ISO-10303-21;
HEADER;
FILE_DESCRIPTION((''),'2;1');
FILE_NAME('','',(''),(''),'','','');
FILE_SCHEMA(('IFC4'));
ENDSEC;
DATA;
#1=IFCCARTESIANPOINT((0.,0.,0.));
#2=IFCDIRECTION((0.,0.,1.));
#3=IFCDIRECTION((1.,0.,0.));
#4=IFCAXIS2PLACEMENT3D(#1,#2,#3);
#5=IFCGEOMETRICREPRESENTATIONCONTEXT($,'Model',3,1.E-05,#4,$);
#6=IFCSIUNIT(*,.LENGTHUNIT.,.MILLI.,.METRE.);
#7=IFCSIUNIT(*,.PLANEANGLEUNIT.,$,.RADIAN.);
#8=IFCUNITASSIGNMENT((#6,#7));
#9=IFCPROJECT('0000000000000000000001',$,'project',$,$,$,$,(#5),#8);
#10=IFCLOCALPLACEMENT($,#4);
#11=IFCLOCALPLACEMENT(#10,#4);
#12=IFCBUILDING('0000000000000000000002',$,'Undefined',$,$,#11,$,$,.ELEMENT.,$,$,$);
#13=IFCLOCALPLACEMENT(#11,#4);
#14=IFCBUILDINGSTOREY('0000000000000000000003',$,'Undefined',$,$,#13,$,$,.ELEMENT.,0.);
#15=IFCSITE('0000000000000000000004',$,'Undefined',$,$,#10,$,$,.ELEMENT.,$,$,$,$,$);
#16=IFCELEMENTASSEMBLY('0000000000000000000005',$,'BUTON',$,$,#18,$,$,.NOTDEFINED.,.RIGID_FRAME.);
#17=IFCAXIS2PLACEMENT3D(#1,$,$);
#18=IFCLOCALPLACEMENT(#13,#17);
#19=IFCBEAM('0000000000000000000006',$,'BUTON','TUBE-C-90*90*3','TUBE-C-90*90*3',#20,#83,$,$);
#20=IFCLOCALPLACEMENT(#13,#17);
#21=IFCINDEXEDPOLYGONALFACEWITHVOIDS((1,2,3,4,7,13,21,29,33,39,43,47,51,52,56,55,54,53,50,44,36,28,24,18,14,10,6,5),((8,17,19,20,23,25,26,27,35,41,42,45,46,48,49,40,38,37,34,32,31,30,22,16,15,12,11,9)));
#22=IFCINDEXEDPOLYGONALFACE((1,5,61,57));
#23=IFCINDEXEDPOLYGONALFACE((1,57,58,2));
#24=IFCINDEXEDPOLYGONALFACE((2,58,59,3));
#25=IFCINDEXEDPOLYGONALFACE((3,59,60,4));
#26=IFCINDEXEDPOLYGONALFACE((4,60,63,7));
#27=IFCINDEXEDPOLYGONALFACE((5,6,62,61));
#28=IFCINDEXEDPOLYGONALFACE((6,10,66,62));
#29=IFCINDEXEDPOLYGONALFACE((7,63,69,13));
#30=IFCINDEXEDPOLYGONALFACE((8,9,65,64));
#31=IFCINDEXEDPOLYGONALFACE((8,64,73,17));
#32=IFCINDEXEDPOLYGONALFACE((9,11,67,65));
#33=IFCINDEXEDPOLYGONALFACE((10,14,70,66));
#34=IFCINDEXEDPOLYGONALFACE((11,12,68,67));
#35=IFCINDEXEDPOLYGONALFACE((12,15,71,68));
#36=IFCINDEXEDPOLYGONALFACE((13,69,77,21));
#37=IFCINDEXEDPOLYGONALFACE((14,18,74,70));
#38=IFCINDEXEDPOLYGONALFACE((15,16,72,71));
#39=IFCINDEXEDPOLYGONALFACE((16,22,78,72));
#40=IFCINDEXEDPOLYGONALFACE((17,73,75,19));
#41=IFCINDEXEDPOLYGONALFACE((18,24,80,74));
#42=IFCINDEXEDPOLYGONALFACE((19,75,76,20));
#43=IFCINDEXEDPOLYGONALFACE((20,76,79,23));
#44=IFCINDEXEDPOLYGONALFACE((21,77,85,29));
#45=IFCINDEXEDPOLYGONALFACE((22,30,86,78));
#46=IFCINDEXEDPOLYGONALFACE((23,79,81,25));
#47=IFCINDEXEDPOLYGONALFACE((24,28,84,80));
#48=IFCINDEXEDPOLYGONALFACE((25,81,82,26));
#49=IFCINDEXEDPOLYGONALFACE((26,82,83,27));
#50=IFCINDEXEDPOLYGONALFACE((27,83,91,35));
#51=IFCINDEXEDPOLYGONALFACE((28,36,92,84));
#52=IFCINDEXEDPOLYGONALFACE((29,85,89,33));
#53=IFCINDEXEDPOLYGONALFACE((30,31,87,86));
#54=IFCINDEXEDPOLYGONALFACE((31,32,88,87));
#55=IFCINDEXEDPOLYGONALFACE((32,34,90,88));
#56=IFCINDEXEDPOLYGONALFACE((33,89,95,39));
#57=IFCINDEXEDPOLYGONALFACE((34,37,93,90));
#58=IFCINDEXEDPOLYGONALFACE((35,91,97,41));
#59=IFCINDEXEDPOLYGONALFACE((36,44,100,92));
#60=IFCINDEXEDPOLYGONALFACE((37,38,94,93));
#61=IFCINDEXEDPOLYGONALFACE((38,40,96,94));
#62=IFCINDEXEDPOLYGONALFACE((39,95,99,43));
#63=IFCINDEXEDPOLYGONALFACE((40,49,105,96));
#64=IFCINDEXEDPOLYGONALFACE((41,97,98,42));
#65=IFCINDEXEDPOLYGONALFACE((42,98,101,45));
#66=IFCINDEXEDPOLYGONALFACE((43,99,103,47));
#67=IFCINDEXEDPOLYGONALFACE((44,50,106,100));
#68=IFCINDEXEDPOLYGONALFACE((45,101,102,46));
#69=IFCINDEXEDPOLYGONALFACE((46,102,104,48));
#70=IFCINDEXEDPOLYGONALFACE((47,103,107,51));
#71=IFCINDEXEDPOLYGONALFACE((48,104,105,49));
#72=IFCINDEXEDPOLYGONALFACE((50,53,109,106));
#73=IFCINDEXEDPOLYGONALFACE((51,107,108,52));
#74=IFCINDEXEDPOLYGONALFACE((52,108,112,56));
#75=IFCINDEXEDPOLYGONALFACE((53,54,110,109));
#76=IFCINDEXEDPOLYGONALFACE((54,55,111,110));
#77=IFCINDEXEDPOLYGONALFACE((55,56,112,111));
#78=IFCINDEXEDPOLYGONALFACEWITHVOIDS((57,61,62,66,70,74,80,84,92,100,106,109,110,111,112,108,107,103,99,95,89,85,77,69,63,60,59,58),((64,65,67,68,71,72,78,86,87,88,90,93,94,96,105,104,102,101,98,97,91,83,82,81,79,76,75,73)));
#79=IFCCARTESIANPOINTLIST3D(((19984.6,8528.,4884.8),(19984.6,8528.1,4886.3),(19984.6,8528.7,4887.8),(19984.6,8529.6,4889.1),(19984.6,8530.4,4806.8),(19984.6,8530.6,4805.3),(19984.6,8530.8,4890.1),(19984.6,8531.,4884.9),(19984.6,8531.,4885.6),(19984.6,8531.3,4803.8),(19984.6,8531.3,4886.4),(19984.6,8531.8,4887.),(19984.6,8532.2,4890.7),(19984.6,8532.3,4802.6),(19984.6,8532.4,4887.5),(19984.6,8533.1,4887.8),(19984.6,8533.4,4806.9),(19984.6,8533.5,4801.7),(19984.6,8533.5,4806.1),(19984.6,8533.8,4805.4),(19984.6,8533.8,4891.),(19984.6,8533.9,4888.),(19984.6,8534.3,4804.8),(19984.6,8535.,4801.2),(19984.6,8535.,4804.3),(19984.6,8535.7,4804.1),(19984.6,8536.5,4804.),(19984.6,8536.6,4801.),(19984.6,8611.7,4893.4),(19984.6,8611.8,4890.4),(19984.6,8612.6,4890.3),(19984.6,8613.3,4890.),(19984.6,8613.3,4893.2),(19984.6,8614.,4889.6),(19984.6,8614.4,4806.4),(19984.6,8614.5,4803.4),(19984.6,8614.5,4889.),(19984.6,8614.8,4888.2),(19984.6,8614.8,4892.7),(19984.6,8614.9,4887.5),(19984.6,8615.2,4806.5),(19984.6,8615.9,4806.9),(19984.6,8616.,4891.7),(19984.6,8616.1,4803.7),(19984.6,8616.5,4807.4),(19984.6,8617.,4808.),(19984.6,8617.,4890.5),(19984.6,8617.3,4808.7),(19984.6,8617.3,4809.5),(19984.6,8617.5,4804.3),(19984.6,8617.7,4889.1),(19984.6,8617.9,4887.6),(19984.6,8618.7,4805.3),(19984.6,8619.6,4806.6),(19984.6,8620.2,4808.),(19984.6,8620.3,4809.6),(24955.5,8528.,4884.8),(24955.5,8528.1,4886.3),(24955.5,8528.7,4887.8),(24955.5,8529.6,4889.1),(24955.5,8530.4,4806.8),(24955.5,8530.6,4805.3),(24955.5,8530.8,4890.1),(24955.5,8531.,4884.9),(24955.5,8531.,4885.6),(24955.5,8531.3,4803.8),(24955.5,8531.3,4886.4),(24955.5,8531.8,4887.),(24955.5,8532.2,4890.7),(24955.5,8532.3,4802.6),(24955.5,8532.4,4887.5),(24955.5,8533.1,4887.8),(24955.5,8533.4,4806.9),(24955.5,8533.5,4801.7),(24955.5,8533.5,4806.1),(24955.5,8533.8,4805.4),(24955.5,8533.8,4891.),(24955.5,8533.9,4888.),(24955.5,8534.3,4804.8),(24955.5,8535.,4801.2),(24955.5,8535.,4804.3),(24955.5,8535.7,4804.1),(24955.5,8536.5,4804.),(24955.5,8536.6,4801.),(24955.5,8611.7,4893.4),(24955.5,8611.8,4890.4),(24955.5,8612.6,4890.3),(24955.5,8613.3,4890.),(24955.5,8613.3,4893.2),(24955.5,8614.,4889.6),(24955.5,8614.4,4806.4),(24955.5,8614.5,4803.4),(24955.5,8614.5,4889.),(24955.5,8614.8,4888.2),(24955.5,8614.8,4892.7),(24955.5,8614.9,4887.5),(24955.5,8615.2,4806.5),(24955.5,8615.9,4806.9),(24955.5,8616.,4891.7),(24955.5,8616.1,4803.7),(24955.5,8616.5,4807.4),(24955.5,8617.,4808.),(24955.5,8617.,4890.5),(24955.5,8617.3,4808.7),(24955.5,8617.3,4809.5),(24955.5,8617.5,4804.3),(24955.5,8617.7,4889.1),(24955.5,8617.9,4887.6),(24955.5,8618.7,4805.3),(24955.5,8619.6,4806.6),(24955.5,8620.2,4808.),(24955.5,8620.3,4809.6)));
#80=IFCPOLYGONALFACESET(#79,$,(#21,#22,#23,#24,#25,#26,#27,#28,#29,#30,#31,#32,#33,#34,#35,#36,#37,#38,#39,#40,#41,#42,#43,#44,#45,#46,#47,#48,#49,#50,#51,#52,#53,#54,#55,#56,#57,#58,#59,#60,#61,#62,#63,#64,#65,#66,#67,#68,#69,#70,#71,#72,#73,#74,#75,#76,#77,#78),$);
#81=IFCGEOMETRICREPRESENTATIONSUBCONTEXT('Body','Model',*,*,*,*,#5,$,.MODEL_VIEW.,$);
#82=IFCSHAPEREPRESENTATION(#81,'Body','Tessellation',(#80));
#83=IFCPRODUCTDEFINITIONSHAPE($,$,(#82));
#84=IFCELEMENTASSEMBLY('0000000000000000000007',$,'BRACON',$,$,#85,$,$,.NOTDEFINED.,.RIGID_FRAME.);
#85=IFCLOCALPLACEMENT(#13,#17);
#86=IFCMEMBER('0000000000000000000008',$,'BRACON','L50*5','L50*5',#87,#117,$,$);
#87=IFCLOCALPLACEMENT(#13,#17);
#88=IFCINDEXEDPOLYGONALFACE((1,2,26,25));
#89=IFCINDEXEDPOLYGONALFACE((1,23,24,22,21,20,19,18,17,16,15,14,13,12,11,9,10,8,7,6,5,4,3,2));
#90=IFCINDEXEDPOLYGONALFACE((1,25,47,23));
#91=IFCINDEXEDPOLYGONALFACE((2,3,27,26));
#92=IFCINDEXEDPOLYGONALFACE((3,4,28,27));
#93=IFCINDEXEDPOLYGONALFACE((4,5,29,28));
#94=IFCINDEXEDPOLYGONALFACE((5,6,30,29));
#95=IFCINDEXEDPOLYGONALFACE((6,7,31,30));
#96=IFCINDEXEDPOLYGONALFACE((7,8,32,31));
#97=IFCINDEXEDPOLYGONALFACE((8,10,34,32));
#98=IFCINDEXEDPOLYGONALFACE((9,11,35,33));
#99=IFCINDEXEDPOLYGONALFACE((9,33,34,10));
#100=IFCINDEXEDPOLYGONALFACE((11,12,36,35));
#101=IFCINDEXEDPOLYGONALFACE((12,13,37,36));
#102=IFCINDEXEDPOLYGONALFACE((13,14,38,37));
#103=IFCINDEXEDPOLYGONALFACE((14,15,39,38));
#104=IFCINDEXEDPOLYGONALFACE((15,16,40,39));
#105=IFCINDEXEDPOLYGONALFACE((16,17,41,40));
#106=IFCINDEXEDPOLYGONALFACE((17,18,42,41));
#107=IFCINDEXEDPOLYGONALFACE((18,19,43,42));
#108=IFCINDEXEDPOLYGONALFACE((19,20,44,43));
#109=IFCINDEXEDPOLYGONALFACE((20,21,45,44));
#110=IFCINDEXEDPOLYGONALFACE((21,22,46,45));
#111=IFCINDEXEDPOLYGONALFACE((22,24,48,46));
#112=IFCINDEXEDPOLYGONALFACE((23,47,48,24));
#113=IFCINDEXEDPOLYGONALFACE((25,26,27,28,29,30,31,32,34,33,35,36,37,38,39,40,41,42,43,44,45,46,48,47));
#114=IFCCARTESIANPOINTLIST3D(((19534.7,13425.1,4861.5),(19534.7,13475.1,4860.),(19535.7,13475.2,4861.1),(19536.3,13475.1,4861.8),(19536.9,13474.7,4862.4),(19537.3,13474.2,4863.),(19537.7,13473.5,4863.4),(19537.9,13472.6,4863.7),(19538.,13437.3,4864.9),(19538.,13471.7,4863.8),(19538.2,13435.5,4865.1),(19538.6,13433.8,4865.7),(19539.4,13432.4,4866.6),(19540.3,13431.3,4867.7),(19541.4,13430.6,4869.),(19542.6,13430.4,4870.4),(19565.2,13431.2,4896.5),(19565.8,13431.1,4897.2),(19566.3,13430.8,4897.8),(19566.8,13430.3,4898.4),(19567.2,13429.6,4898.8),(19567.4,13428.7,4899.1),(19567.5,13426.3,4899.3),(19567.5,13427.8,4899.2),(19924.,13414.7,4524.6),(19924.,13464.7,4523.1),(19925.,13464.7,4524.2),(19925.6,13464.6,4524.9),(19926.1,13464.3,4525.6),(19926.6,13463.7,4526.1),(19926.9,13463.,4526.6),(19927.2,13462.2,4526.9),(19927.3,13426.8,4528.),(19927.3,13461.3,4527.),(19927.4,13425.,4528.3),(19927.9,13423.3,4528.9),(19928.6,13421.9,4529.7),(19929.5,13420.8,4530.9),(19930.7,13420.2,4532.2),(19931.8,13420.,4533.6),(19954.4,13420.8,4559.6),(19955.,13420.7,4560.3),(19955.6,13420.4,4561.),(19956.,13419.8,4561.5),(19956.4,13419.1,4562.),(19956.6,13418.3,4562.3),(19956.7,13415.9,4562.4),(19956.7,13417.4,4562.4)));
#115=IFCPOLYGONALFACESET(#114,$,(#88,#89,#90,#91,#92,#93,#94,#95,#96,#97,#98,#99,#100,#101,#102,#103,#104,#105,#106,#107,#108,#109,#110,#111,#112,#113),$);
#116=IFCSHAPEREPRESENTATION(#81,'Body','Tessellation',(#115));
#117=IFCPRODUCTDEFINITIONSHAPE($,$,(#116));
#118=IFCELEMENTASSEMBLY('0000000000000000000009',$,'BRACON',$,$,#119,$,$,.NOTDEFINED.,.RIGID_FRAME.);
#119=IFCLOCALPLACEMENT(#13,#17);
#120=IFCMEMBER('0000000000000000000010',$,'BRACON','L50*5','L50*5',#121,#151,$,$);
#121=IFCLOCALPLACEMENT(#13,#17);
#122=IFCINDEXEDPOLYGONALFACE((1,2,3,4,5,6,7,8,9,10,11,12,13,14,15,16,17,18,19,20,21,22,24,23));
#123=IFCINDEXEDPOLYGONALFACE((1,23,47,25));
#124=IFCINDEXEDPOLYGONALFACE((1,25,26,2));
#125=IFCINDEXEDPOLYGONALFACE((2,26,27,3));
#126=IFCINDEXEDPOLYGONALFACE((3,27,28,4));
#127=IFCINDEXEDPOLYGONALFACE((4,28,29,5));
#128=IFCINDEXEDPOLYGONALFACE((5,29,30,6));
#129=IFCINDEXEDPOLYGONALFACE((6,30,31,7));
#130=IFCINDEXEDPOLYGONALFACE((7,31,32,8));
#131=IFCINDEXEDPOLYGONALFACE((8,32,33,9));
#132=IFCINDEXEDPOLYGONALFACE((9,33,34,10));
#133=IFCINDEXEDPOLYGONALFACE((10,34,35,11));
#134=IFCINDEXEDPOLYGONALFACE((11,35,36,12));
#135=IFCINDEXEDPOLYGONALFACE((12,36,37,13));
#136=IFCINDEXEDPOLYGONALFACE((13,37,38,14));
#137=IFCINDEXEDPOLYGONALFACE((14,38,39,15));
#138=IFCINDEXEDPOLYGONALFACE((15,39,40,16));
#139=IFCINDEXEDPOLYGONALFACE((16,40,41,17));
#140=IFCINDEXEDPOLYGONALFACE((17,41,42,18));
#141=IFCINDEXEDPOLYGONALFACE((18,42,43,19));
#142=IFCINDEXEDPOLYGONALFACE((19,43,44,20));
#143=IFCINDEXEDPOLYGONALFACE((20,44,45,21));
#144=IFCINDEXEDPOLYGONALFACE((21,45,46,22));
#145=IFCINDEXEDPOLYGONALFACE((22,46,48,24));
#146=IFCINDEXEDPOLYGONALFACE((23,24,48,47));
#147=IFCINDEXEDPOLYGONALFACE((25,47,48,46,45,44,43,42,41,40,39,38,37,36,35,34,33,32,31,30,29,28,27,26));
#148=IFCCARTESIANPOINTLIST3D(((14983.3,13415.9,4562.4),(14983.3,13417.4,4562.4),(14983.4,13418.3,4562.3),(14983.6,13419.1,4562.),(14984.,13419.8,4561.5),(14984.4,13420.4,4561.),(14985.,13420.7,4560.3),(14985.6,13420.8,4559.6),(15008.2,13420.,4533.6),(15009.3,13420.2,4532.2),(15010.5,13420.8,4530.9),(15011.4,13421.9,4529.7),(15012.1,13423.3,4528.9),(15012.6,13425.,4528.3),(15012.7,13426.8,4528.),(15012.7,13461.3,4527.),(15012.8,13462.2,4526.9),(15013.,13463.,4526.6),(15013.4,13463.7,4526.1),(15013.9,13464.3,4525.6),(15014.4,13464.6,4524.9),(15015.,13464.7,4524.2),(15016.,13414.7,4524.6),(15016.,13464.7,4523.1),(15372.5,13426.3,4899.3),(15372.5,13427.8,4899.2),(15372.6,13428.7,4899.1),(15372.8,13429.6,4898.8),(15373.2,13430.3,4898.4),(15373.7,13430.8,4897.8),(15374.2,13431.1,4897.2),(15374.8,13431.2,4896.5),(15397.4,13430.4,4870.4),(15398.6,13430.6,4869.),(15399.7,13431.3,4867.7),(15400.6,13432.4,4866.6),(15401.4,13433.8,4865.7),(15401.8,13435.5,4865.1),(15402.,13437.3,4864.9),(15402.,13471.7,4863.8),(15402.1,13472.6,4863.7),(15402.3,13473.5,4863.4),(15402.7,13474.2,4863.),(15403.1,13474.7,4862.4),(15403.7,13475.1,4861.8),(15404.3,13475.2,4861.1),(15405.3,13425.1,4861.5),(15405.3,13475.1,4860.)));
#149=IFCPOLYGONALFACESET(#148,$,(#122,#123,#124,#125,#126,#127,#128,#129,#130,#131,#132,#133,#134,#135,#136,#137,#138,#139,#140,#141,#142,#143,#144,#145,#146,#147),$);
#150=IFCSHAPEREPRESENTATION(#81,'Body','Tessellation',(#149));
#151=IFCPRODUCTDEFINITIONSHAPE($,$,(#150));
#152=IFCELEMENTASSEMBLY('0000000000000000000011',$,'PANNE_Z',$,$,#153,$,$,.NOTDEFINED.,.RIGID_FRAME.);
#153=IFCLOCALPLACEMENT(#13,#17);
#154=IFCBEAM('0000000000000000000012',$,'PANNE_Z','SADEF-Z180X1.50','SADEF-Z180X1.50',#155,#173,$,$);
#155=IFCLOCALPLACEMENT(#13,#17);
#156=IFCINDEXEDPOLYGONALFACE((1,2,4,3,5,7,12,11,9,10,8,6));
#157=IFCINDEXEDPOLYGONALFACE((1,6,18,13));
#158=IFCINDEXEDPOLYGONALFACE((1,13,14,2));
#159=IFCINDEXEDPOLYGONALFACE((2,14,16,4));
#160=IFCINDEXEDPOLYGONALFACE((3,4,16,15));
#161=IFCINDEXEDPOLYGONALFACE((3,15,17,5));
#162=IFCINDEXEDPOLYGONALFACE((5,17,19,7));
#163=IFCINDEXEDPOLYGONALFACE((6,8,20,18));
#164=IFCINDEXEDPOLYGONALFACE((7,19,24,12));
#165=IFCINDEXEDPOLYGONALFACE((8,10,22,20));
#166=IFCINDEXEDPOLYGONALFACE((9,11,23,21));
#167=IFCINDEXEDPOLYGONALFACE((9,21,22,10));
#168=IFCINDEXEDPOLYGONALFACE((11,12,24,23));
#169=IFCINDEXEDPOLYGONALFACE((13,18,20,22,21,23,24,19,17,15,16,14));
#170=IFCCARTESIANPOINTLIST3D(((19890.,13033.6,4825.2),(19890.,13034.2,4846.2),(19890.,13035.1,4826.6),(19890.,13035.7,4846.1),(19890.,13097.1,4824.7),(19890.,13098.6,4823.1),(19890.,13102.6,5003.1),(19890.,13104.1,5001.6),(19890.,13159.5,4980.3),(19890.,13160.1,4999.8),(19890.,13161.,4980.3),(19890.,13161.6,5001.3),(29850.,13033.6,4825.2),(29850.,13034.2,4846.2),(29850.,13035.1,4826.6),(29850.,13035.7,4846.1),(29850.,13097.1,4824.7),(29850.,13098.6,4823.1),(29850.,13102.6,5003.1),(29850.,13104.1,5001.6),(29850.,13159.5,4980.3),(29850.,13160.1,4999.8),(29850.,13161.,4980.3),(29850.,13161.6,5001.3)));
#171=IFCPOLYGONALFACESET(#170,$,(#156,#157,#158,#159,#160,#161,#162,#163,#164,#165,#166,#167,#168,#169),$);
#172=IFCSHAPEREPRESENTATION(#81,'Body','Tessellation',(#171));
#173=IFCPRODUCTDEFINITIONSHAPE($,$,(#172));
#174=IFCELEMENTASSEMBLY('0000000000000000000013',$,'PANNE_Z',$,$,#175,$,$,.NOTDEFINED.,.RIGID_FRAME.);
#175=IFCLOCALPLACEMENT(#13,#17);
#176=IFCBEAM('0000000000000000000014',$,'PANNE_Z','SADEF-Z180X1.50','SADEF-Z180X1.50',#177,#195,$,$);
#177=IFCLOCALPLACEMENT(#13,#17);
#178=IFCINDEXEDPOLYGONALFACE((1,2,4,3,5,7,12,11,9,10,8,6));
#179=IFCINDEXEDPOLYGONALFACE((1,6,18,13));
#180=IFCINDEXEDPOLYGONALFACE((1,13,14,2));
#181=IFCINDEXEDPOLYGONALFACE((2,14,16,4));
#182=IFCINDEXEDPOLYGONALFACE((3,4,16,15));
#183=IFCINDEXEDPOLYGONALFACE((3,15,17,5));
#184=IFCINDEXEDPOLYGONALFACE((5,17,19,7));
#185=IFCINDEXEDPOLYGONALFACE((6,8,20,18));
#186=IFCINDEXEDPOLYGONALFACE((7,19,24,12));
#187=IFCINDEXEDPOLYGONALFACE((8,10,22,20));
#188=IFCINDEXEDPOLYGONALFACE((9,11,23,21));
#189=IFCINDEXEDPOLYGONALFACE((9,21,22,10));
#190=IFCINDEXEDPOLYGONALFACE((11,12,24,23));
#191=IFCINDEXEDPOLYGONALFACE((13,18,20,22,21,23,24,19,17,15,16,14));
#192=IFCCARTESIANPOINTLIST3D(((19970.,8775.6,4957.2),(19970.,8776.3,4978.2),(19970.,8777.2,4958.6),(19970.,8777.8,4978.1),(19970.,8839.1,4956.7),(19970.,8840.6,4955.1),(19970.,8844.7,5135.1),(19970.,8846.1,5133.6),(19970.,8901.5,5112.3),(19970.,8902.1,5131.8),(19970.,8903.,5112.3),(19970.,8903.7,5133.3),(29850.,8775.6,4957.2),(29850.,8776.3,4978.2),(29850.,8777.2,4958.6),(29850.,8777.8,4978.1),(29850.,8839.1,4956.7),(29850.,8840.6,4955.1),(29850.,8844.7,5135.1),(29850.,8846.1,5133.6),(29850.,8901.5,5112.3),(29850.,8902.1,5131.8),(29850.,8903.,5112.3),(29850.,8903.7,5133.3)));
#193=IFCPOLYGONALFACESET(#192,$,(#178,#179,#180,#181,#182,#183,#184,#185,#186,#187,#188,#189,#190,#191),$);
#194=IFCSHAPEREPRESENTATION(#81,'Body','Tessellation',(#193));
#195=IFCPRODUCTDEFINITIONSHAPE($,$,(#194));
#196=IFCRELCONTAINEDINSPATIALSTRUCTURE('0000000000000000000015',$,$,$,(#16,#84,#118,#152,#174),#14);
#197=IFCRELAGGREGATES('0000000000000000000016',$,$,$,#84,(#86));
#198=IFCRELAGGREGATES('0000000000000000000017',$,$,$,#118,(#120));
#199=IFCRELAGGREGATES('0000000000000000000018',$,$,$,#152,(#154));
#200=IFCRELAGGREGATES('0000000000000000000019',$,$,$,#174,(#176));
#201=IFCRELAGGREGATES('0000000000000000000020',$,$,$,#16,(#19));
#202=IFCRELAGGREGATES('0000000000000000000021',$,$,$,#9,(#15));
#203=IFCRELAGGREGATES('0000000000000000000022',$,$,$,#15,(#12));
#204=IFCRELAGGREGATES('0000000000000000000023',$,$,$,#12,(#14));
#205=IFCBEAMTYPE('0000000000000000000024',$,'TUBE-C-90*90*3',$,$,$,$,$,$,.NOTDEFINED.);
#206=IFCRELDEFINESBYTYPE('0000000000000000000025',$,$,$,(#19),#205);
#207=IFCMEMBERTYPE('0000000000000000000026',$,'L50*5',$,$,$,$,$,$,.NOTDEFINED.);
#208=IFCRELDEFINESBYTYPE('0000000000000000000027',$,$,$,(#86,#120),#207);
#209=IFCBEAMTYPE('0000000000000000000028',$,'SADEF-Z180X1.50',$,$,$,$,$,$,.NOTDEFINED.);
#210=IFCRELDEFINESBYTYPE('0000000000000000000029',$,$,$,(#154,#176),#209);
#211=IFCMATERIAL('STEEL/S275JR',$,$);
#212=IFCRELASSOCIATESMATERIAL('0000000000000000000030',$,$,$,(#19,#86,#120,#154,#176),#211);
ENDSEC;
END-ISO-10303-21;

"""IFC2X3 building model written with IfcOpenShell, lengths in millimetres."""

from ifc_helpers import new_model, si_unit, frame, origin_with_axes, origin_2d_with_axis, place, context, subcontext, project, spatial, polyline, hollow_rectangle, l_section, outline, extrude, clip, halfspace, material, type_object, element, aggregate, save


model = new_model("IFC2X3")

# Units and contexts
model_context = context("Model", 3, precision=1e-05, world=origin_with_axes())
body_context = subcontext(model_context, "Body", "Model", "MODEL_VIEW")
ifc_project = project(units=[si_unit("LENGTHUNIT", "METRE", prefix="MILLI"), si_unit("PLANEANGLEUNIT", "RADIAN")], contexts=[model_context])

# Site, building, storey
site_placement = place(None, origin_with_axes())
site = spatial("IfcSite", under=ifc_project, at=site_placement, Name="Undefined", CompositionType="ELEMENT")
building_placement = place(site_placement, origin_with_axes())
building = spatial("IfcBuilding", under=site, at=building_placement, Name="Undefined", CompositionType="ELEMENT")
storey_placement = place(building_placement, origin_with_axes())
storey = spatial("IfcBuildingStorey", under=building, at=storey_placement, Name="Undefined", CompositionType="ELEMENT", Elevation=0.0)

# Element assembly, beam
ifc_material_1 = material(Name="STEEL/S275JR")
beam_type_1 = type_object("IfcBeamType", Name="TUBE-C-90*90*3", PredefinedType="NOTDEFINED")
assembly_1_placement = place(storey_placement, origin_with_axes())
assembly_1 = element("IfcElementAssembly", 1, at=assembly_1_placement, inside=storey, Name="BUTON", AssemblyPlace="NOTDEFINED", PredefinedType="RIGID_FRAME")
beam_1_placement = place(assembly_1_placement, frame((19970.0, 8574.2, 4847.2), z_axis=(0.0, 0.99952, 0.030986), x_axis=(1.0, 0.0, 0.0)))
beam_1 = element("IfcBeam", 2, at=beam_1_placement, type_object=beam_type_1, material=ifc_material_1, Name="BUTON", Description="TUBE-C-90*90*3", ObjectType="TUBE-C-90*90*3", context=body_context, shape_type="Clipping", body=[
    clip(clip(extrude(hollow_rectangle(XDim=90.0, YDim=90.0, WallThickness=3.0, InnerFilletRadius=3.0, OuterFilletRadius=6.0, at=origin_2d_with_axis()), frame((4985.5, 0.0, 0.0), z_axis=(-1.0, 0.0, 0.0), x_axis=(0.0, -1.0, 0.0)), (0.0, 0.0, 1.0), 4970.9), halfspace(frame((4985.5, 0.0, -45.0), z_axis=(-1.0, 0.0, 0.0), x_axis=(0.0, 1.0, 0.0)), True)), halfspace(frame((14.5, 0.0, -45.0), z_axis=(1.0, 0.0, 0.0), x_axis=(0.0, -1.0, 0.0)), True)),
])

# Element assemblies, members
assembly_2_placement = place(storey_placement, origin_with_axes())
assembly_2 = element("IfcElementAssembly", 3, at=assembly_2_placement, inside=storey, Name="BRACON", AssemblyPlace="NOTDEFINED", PredefinedType="RIGID_FRAME")
member_type = type_object("IfcMemberType", Name="L50*5", PredefinedType="NOTDEFINED")
member_1_placement = place(assembly_2_placement, frame((19940.3, 13440.3, 4542.8), z_axis=(0.654574, 0.023425, 0.755635), x_axis=(-0.755998, 0.020283, 0.65426)))
member_1 = element("IfcMember", 4, at=member_1_placement, type_object=member_type, material=ifc_material_1, Name="BRACON", Description="L50*5", ObjectType="L50*5", context=body_context, shape_type="SweptSolid", body=[
    extrude(l_section(Depth=50.0, Width=50.0, Thickness=5.0, FilletRadius=7.0, EdgeRadius=3.5, at=origin_2d_with_axis()), frame((514.9, 0.0, 0.0), z_axis=(-1.0, 0.0, 0.0), x_axis=(0.0, -1.0, 0.0)), (0.0, 0.0, 1.0), 514.9),
])
aggregate(assembly_2, [member_1])
assembly_3_placement = place(storey_placement, origin_with_axes())
assembly_3 = element("IfcElementAssembly", 5, at=assembly_3_placement, inside=storey, Name="BRACON", AssemblyPlace="NOTDEFINED", PredefinedType="RIGID_FRAME")
member_2_placement = place(assembly_3_placement, frame((15388.9, 13450.7, 4879.6), z_axis=(-0.654574, 0.023425, 0.755635), x_axis=(-0.755998, -0.020283, -0.65426)))
member_2 = element("IfcMember", 6, at=member_2_placement, type_object=member_type, material=ifc_material_1, Name="BRACON", Description="L50*5", ObjectType="L50*5", context=body_context, shape_type="SweptSolid", body=[
    extrude(l_section(Depth=50.0, Width=50.0, Thickness=5.0, FilletRadius=7.0, EdgeRadius=3.5, at=origin_2d_with_axis()), frame((514.9, 0.0, 0.0), z_axis=(-1.0, 0.0, 0.0), x_axis=(0.0, -1.0, 0.0)), (0.0, 0.0, 1.0), 514.9),
])
aggregate(assembly_3, [member_2])

# Element assemblies, beams
assembly_4_placement = place(storey_placement, origin_with_axes())
assembly_4 = element("IfcElementAssembly", 7, at=assembly_4_placement, inside=storey, Name="PANNE_Z", AssemblyPlace="NOTDEFINED", PredefinedType="RIGID_FRAME")
beam_type_2 = type_object("IfcBeamType", Name="SADEF-Z180X1.50", PredefinedType="NOTDEFINED")
beam_2_placement = place(assembly_4_placement, frame((19890.0, 13100.6, 4913.1), z_axis=(0.0, 0.031032, 0.999518), x_axis=(1.0, 0.0, 0.0)))
beam_2 = element("IfcBeam", 8, at=beam_2_placement, type_object=beam_type_2, material=ifc_material_1, Name="PANNE_Z", Description="SADEF-Z180X1.50", ObjectType="SADEF-Z180X1.50", context=body_context, shape_type="SweptSolid", body=[
    extrude(outline(polyline([(-56.7, 69.0), (-58.2, 69.0), (-58.2, 90.0), (0.8, 90.0), (0.7, -88.5), (62.7, -88.5), (62.7, -69.0), (64.2, -69.0), (64.2, -90.0), (-0.8, -90.0), (-0.7, 88.5), (-56.7, 88.5), (-56.7, 69.0)])), frame((9960.0, 0.0, 0.0), z_axis=(-1.0, 0.0, 0.0), x_axis=(0.0, -1.0, 0.0)), (0.0, 0.0, 1.0), 9960.0),
])
aggregate(assembly_4, [beam_2])
assembly_5_placement = place(storey_placement, origin_with_axes())
assembly_5 = element("IfcElementAssembly", 9, at=assembly_5_placement, inside=storey, Name="PANNE_Z", AssemblyPlace="NOTDEFINED", PredefinedType="RIGID_FRAME")
beam_3_placement = place(assembly_5_placement, frame((19970.0, 8842.6, 5045.1), z_axis=(0.0, 0.031032, 0.999518), x_axis=(1.0, 0.0, 0.0)))
beam_3 = element("IfcBeam", 10, at=beam_3_placement, type_object=beam_type_2, material=ifc_material_1, Name="PANNE_Z", Description="SADEF-Z180X1.50", ObjectType="SADEF-Z180X1.50", context=body_context, shape_type="SweptSolid", body=[
    extrude(outline(polyline([(-56.7, 69.0), (-58.2, 69.0), (-58.2, 90.0), (0.8, 90.0), (0.7, -88.5), (62.7, -88.5), (62.7, -69.0), (64.2, -69.0), (64.2, -90.0), (-0.8, -90.0), (-0.7, 88.5), (-56.7, 88.5), (-56.7, 69.0)])), frame((9880.0, 0.0, 0.0), z_axis=(-1.0, 0.0, 0.0), x_axis=(0.0, -1.0, 0.0)), (0.0, 0.0, 1.0), 9880.0),
])
aggregate(assembly_5, [beam_3])

aggregate(assembly_1, [beam_1])

save(model, "model.ifc")
